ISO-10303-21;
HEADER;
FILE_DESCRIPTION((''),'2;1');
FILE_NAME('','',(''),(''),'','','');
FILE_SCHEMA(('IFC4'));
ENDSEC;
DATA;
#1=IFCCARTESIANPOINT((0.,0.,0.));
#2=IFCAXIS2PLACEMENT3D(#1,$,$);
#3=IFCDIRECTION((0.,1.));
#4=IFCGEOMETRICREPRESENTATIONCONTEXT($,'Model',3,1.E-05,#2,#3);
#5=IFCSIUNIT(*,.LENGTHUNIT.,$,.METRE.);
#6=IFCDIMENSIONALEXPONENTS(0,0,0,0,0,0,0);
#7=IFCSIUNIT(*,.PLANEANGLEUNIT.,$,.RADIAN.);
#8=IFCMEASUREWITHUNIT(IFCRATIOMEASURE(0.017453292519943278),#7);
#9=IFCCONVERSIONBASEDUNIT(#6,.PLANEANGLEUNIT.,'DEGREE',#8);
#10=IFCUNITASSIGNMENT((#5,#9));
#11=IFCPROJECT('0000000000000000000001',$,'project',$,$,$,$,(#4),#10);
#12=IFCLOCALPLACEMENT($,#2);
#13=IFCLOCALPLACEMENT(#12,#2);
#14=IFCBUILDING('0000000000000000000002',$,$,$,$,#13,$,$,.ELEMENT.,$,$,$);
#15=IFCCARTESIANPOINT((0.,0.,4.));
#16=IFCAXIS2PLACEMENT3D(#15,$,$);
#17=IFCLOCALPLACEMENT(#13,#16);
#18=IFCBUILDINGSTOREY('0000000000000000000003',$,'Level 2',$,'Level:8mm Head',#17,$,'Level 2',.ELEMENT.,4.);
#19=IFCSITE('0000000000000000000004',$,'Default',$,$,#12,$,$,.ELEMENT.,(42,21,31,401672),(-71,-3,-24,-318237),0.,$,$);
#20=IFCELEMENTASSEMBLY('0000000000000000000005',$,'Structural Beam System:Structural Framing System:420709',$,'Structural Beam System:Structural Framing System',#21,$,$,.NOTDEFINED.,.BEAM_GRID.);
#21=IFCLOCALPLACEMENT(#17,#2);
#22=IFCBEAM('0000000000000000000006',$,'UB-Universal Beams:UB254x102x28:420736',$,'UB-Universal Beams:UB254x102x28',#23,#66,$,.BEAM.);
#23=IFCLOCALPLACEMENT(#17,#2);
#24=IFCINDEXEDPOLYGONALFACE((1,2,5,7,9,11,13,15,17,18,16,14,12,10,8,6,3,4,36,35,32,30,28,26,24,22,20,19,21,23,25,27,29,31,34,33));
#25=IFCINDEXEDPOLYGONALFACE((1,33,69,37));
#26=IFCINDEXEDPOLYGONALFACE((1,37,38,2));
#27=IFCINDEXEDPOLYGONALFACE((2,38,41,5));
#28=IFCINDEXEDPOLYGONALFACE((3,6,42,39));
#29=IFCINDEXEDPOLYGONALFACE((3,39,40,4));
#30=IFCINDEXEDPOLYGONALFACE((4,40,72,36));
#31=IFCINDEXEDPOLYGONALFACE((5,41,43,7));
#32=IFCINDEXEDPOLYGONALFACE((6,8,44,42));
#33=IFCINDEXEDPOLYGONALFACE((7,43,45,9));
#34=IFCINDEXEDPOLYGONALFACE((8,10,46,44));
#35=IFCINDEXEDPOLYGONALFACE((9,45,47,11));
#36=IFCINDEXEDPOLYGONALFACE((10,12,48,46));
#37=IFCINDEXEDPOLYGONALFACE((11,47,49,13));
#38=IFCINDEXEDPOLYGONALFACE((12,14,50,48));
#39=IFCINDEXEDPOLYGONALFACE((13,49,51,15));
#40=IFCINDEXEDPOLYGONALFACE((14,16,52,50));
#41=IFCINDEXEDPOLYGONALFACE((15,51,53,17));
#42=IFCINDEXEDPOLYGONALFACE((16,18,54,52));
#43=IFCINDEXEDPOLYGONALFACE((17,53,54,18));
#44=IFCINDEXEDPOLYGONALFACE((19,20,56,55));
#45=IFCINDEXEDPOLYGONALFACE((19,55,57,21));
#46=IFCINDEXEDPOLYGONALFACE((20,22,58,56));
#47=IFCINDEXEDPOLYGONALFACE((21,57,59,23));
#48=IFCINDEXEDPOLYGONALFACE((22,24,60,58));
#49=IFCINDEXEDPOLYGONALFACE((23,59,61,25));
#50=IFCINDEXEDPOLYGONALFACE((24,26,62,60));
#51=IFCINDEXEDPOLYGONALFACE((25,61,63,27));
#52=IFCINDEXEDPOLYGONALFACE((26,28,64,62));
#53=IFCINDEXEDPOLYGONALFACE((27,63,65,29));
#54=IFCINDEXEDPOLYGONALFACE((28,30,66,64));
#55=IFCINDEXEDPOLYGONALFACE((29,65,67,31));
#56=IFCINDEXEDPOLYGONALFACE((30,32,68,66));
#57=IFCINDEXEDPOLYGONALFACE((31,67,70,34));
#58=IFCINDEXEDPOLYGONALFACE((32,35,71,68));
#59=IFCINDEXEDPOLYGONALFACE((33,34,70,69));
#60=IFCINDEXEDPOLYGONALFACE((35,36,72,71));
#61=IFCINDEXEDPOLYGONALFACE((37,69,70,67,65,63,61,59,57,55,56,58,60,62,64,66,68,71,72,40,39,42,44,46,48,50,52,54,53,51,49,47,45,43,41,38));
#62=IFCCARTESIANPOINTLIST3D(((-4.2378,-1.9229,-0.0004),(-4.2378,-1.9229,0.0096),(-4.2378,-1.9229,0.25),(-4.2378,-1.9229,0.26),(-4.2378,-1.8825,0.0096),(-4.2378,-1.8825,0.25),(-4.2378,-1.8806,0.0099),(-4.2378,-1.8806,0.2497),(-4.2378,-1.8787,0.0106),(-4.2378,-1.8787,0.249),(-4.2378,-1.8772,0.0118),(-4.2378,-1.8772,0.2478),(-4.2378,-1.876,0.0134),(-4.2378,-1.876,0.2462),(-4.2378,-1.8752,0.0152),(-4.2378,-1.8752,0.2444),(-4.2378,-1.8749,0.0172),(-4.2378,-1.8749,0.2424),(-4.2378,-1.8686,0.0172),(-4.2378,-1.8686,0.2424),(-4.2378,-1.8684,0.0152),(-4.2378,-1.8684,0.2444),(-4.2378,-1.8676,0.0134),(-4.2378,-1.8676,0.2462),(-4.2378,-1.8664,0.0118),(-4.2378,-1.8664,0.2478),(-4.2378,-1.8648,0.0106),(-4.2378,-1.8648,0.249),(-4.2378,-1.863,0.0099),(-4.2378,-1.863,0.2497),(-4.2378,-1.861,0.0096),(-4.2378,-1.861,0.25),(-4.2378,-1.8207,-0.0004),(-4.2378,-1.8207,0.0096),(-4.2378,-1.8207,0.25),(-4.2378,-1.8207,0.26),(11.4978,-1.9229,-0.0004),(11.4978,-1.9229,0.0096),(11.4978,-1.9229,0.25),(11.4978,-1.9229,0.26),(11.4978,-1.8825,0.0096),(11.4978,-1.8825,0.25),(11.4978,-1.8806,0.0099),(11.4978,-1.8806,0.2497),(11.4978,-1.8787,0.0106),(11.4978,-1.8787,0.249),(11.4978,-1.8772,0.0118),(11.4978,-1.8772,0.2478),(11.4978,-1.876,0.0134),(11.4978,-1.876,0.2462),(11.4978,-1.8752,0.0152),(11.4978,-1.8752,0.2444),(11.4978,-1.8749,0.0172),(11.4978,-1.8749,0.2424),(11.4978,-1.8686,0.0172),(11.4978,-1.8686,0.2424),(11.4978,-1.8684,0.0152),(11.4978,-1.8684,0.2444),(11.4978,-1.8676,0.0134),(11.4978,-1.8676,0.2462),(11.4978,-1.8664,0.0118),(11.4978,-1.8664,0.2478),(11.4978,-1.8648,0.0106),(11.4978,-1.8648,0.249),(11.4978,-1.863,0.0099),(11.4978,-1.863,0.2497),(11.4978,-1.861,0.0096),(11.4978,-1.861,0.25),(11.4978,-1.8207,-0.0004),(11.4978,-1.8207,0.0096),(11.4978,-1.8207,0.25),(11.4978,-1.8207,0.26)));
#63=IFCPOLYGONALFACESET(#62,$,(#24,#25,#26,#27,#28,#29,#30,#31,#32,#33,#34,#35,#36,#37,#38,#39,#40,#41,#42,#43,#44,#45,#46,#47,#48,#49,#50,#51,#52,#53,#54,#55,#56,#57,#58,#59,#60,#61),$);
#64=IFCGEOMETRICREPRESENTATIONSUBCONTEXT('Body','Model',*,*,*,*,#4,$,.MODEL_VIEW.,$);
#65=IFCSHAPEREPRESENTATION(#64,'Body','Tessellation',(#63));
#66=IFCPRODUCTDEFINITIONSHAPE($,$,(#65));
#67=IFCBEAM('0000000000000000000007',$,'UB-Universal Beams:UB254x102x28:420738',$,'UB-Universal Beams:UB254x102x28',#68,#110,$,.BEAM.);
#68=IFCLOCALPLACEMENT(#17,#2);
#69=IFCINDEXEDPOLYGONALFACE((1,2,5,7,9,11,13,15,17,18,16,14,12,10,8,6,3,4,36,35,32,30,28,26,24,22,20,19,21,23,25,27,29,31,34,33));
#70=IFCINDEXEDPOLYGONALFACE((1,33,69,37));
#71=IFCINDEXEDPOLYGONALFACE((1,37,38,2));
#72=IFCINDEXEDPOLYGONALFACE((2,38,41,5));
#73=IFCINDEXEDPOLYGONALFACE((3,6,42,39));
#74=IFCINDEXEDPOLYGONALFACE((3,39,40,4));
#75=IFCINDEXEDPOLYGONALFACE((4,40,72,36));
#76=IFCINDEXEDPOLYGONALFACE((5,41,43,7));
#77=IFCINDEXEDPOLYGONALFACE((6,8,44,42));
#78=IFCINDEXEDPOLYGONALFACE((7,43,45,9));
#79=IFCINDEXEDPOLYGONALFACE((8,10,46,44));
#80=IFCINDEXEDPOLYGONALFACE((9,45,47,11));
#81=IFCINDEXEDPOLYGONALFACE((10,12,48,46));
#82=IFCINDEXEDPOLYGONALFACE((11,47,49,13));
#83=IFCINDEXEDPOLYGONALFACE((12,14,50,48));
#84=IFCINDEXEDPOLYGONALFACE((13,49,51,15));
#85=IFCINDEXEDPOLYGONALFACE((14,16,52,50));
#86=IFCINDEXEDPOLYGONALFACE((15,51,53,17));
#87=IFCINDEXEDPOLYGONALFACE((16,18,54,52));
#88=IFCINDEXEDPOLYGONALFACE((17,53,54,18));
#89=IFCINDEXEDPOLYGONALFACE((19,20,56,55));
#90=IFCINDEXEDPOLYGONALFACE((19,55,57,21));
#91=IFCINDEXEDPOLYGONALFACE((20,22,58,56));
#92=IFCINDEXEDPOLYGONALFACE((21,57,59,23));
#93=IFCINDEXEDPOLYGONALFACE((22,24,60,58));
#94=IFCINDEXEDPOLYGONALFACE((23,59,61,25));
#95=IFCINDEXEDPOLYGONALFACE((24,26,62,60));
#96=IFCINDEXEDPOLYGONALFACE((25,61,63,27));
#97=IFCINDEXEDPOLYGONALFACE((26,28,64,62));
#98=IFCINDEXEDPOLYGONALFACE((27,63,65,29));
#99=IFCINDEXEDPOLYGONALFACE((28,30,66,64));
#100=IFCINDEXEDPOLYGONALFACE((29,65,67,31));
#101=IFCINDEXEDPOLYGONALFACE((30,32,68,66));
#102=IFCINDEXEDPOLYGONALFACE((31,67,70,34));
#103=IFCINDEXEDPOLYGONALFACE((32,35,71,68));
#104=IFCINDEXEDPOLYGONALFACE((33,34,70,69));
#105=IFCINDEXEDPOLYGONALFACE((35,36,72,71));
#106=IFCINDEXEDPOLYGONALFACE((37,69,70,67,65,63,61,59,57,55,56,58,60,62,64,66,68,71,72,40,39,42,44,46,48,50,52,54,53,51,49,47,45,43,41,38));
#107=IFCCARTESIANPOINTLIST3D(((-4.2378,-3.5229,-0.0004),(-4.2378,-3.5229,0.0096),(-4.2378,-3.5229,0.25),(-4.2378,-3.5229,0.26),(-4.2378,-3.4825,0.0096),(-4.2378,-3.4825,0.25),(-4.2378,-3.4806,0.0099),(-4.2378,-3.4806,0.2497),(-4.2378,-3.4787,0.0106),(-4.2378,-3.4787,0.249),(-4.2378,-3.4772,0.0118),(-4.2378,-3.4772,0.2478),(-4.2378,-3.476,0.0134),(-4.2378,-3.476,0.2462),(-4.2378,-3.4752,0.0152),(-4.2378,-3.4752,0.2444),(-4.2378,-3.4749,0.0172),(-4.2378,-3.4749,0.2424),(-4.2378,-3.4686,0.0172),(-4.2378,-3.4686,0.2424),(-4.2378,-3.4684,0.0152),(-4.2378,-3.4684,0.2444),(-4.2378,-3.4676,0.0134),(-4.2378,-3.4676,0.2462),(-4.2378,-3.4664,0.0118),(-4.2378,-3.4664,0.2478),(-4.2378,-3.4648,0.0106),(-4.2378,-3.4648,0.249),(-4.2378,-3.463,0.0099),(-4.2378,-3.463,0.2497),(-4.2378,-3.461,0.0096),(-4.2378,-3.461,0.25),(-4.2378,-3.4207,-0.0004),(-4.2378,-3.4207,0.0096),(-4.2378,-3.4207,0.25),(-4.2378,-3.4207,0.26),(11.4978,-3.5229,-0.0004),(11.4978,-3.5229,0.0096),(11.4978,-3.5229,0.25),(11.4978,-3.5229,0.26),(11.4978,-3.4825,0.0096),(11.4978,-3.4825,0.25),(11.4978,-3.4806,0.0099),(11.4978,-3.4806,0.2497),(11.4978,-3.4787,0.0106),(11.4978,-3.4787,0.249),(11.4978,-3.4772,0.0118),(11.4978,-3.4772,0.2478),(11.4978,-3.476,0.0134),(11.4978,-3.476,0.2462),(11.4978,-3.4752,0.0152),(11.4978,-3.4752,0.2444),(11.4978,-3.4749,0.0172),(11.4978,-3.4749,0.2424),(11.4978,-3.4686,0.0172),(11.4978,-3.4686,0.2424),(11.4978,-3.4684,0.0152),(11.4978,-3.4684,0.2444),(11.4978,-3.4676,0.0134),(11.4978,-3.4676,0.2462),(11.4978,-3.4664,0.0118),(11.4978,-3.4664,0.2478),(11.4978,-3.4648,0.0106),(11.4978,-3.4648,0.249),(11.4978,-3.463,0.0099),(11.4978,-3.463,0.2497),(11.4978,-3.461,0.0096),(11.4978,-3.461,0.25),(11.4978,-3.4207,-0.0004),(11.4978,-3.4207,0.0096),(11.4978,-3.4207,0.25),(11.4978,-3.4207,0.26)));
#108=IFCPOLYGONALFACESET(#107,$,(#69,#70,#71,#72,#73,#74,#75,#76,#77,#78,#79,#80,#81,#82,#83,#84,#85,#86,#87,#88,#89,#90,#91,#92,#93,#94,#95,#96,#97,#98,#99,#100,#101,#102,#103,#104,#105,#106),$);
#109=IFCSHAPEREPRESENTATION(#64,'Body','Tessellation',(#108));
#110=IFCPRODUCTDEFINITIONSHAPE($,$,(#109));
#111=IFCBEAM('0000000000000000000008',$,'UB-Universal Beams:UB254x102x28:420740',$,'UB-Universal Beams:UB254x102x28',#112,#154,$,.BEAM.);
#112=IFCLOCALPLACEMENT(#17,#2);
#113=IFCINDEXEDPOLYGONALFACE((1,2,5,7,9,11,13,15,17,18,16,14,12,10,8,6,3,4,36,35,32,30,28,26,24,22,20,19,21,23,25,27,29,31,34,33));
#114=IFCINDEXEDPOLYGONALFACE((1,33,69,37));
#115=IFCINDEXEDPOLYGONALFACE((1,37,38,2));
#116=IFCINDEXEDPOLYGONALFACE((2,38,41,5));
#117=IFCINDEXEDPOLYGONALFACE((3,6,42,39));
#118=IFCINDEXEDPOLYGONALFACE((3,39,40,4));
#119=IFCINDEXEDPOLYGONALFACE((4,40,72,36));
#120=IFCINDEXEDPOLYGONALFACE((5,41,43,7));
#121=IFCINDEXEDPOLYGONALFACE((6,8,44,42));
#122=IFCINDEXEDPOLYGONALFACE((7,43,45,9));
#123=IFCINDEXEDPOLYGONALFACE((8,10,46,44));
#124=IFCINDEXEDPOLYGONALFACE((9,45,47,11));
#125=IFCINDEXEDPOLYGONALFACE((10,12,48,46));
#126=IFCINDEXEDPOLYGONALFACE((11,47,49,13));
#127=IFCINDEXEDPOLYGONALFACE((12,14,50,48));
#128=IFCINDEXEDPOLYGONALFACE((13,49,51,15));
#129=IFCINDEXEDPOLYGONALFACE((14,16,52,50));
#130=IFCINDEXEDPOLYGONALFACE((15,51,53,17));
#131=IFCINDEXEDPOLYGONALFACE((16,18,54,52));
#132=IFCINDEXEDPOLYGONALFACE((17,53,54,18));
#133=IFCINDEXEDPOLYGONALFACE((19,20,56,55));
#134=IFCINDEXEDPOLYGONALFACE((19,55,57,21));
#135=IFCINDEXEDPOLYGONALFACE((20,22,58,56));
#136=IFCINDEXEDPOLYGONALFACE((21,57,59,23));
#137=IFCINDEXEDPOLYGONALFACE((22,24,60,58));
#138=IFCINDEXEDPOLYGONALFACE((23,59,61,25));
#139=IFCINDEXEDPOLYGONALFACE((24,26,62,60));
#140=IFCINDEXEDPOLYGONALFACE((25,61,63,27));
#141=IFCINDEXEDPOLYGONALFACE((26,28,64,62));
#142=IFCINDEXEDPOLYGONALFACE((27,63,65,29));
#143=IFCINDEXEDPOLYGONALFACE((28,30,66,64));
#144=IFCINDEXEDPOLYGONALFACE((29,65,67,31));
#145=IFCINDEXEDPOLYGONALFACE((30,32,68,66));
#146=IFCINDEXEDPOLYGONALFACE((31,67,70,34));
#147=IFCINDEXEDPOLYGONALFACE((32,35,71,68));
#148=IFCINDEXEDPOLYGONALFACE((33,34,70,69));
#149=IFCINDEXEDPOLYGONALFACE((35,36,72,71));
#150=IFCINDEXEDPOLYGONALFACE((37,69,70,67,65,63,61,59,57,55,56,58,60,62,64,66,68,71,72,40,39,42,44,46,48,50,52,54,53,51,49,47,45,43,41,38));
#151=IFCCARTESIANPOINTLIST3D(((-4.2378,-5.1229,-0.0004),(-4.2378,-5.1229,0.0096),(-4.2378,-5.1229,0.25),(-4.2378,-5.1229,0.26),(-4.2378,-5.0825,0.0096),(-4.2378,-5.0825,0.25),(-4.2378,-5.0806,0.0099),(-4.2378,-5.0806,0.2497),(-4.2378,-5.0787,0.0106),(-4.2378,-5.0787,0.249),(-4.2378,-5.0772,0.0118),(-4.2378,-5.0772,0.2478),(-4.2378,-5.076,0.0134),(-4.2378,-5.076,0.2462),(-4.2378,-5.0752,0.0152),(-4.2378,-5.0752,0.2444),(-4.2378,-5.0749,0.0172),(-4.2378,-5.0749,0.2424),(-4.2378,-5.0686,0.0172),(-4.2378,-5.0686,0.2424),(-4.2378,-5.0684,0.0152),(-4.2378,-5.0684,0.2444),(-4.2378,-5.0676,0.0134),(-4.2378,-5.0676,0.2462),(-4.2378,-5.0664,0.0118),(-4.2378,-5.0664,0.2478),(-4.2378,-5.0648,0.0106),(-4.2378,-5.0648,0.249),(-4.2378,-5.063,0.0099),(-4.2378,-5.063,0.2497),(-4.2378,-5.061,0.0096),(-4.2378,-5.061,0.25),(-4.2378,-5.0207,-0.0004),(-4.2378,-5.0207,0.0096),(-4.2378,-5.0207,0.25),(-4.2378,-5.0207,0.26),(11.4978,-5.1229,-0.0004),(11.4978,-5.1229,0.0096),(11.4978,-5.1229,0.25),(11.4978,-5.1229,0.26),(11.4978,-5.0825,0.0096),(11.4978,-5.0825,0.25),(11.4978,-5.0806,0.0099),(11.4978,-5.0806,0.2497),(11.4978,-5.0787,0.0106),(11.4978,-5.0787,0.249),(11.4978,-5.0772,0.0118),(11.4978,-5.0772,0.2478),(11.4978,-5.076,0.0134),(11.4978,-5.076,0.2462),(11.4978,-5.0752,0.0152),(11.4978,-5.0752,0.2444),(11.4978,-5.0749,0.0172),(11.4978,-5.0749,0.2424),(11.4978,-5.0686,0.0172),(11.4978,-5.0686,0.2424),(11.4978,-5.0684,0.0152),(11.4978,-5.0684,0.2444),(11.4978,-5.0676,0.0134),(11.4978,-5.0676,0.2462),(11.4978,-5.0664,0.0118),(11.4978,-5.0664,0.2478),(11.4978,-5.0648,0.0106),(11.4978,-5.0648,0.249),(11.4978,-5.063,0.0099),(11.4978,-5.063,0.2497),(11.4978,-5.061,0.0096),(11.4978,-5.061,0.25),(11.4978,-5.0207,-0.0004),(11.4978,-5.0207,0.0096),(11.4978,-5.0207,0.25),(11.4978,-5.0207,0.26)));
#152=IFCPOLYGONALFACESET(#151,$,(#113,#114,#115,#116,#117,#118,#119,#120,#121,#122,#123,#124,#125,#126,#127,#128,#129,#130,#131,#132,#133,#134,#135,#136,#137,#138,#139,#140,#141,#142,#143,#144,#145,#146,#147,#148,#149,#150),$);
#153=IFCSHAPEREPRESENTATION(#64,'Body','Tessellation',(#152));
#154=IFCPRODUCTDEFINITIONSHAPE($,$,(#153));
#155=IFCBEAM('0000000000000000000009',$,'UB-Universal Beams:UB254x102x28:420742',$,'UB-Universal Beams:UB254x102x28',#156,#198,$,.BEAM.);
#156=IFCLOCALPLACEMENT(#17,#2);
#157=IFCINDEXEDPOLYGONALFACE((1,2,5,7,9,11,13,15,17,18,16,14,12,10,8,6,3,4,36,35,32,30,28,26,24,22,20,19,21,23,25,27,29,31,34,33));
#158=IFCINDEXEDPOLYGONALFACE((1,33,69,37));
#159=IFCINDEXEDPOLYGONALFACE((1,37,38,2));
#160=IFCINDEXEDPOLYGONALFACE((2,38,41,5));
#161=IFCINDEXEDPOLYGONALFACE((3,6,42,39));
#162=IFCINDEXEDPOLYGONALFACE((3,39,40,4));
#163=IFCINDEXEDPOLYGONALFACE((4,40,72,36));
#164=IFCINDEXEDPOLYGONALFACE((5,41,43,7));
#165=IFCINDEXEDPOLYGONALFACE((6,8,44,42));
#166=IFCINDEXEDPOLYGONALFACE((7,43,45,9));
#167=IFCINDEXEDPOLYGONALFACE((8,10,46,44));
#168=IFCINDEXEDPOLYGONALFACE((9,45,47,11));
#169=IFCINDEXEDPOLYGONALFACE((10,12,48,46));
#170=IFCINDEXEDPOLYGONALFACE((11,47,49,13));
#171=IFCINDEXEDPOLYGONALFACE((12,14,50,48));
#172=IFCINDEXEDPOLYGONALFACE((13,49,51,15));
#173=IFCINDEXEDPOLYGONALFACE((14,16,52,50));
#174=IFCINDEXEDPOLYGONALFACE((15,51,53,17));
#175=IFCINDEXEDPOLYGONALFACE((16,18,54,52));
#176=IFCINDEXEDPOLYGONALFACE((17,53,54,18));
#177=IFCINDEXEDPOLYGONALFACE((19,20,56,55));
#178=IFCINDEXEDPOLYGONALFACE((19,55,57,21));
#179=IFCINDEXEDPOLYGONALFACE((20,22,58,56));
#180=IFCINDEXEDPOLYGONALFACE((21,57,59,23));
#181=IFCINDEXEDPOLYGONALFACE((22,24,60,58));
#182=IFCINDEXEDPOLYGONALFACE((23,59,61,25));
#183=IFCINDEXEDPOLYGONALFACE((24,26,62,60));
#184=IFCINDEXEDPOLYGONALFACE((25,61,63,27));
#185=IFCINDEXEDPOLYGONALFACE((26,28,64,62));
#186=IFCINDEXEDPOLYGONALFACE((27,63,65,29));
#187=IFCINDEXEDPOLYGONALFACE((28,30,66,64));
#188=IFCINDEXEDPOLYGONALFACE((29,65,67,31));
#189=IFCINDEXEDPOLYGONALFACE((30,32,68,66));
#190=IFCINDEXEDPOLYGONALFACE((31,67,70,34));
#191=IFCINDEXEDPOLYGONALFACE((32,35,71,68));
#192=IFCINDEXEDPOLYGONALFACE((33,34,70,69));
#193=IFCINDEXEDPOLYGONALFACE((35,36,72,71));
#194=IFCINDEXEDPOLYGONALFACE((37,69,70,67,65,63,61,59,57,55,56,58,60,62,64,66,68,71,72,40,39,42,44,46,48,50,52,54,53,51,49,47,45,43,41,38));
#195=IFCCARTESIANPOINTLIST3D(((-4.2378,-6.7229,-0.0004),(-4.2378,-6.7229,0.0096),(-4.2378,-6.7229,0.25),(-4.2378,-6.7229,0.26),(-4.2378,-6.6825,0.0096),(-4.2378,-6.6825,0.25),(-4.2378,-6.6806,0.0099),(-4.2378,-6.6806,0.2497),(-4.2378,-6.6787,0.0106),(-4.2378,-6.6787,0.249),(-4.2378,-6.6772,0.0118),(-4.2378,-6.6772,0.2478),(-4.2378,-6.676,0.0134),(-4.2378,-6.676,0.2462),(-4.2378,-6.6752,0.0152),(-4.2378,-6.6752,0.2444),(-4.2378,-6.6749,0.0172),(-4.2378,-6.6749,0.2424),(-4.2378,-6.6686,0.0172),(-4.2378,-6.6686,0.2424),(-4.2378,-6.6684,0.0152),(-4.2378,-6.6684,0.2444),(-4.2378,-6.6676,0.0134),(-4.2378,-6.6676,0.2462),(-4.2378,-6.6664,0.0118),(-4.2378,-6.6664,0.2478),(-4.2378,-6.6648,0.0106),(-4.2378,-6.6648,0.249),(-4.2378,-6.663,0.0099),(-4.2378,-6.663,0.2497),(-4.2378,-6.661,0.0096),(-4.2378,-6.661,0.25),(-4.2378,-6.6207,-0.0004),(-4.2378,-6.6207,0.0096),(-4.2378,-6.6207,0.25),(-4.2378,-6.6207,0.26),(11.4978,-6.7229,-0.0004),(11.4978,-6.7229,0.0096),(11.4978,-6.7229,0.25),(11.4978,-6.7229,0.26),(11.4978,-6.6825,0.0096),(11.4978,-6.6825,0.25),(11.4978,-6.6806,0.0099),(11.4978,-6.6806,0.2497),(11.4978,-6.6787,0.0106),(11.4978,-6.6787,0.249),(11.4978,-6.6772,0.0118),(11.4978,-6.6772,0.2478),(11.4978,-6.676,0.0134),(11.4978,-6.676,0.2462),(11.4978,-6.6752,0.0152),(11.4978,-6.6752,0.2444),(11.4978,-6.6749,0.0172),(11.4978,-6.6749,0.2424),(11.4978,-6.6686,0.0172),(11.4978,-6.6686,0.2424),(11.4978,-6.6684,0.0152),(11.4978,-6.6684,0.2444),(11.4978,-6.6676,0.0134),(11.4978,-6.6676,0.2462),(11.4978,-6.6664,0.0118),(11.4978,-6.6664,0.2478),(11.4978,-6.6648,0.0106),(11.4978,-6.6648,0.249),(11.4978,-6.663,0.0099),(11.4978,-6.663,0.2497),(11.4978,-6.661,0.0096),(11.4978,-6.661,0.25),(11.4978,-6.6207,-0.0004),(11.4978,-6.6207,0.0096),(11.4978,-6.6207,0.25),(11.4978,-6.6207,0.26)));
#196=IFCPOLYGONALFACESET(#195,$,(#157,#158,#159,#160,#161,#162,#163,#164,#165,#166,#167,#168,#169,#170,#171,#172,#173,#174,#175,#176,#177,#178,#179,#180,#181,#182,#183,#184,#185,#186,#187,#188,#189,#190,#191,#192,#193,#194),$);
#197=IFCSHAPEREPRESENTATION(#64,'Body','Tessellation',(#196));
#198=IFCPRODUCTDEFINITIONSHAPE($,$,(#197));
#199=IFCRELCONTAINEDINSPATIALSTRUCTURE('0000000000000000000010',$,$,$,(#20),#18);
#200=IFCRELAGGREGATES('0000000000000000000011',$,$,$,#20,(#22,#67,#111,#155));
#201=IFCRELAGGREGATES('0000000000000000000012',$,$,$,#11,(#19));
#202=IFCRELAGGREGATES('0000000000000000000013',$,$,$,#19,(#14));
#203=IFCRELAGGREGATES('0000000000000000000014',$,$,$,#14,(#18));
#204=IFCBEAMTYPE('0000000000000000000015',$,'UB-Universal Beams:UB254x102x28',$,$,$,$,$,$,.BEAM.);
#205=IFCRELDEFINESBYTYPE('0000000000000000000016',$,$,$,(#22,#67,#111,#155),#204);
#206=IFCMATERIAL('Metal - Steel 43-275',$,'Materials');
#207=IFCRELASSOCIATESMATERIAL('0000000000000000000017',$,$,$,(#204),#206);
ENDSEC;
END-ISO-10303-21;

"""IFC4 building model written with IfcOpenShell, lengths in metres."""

from ifc_helpers import new_model, entity, si_unit, converted_unit, direction, frame, frame_2d, origin, place, context, subcontext, project, spatial, i_section, extrude, source, transform, mapped, material, material_profile, profile_set, type_object, type_shapes, element, aggregate, save


model = new_model("IFC4")

# Units and contexts
model_context = context("Model", 3, precision=1e-05, world=origin(), true_north=direction((0.0, 1.0)))
body_context = subcontext(model_context, "Body", "Model", "MODEL_VIEW")
ifc_project = project(units=[si_unit("LENGTHUNIT", "METRE"), converted_unit("PLANEANGLEUNIT", "DEGREE", entity("IfcRatioMeasure", 0.017453292519943278), si_unit("PLANEANGLEUNIT", "RADIAN"), dimensions=[0, 0, 0, 0, 0, 0, 0])], contexts=[model_context])

# Site, building, storey
site_placement = place(None, origin())
site = spatial("IfcSite", under=ifc_project, at=site_placement, Name="Default", CompositionType="ELEMENT", RefLatitude=(42, 21, 31, 401672), RefLongitude=(-71, -3, -24, -318237), RefElevation=0.0)
building_placement = place(site_placement, origin())
building = spatial("IfcBuilding", under=site, at=building_placement, CompositionType="ELEMENT")
storey_placement = place(building_placement, frame((0.0, 0.0, 4.0)))
storey = spatial("IfcBuildingStorey", under=building, at=storey_placement, Name="Level 2", ObjectType="Level:8mm Head", LongName="Level 2", CompositionType="ELEMENT", Elevation=4.0)

# Shared definitions
ifc_material_1 = material(Name="Metal - Steel 43-275", Category="Materials")

# Element assembly, beams
assembly_placement = place(storey_placement, origin())
assembly = element("IfcElementAssembly", 1, at=assembly_placement, inside=storey, Name="Structural Beam System:Structural Framing System:420709", ObjectType="Structural Beam System:Structural Framing System", AssemblyPlace="NOTDEFINED", PredefinedType="BEAM_GRID")
ifc_material_profile_1 = material_profile(ifc_material_1, i_section(OverallWidth=0.1022, OverallDepth=0.2604, WebThickness=0.0063, FlangeThickness=0.01, FilletRadius=0.0076, at=frame_2d((0.0, 0.0), x_axis=(0.0, 1.0))), Name="UB254x102x28")
ifc_profile_set_1 = profile_set([ifc_material_profile_1], Name="UB254x102x28")
beam_type_1 = type_object("IfcBeamType", Name="UB-Universal Beams:UB254x102x28", PredefinedType="BEAM", material=ifc_profile_set_1)
shared_shape_1 = source(origin(), body_context, "Body", "SweptSolid", [
    extrude(i_section(OverallWidth=0.1022, OverallDepth=0.2604, WebThickness=0.0063, FlangeThickness=0.01, FilletRadius=0.0076, at=frame_2d((0.0, 0.0), x_axis=(0.0, 1.0))), frame((-7.8373, 0.0, 0.0), z_axis=(1.0, 0.0, 0.0), x_axis=(0.0, 0.0, -1.0)), (0.0, 0.0, 1.0), 15.7356),
])
type_shapes(beam_type_1, [shared_shape_1])
beam_1_placement = place(assembly_placement, frame((3.5995, -1.8718, 0.1298)))
beam_1 = element("IfcBeam", 2, at=beam_1_placement, type_object=beam_type_1, Name="UB-Universal Beams:UB254x102x28:420736", ObjectType="UB-Universal Beams:UB254x102x28", PredefinedType="BEAM", context=body_context, shape_type="MappedRepresentation", body=[
    mapped(shared_shape_1, transform((0.0, 0.0, 0.0), scale=1.0)),
])
beam_2_placement = place(assembly_placement, frame((3.5995, -3.4718, 0.1298)))
beam_2 = element("IfcBeam", 3, at=beam_2_placement, type_object=beam_type_1, Name="UB-Universal Beams:UB254x102x28:420738", ObjectType="UB-Universal Beams:UB254x102x28", PredefinedType="BEAM", context=body_context, shape_type="MappedRepresentation", body=[
    mapped(shared_shape_1, transform((0.0, 0.0, 0.0), scale=1.0)),
])
beam_3_placement = place(assembly_placement, frame((3.5995, -5.0718, 0.1298)))
beam_3 = element("IfcBeam", 4, at=beam_3_placement, type_object=beam_type_1, Name="UB-Universal Beams:UB254x102x28:420740", ObjectType="UB-Universal Beams:UB254x102x28", PredefinedType="BEAM", context=body_context, shape_type="MappedRepresentation", body=[
    mapped(shared_shape_1, transform((0.0, 0.0, 0.0), scale=1.0)),
])
beam_4_placement = place(assembly_placement, frame((3.5995, -6.6718, 0.1298)))
beam_4 = element("IfcBeam", 5, at=beam_4_placement, type_object=beam_type_1, Name="UB-Universal Beams:UB254x102x28:420742", ObjectType="UB-Universal Beams:UB254x102x28", PredefinedType="BEAM", context=body_context, shape_type="MappedRepresentation", body=[
    mapped(shared_shape_1, transform((0.0, 0.0, 0.0), scale=1.0)),
])
aggregate(assembly, [beam_1, beam_2, beam_3, beam_4])

save(model, "model.ifc")
